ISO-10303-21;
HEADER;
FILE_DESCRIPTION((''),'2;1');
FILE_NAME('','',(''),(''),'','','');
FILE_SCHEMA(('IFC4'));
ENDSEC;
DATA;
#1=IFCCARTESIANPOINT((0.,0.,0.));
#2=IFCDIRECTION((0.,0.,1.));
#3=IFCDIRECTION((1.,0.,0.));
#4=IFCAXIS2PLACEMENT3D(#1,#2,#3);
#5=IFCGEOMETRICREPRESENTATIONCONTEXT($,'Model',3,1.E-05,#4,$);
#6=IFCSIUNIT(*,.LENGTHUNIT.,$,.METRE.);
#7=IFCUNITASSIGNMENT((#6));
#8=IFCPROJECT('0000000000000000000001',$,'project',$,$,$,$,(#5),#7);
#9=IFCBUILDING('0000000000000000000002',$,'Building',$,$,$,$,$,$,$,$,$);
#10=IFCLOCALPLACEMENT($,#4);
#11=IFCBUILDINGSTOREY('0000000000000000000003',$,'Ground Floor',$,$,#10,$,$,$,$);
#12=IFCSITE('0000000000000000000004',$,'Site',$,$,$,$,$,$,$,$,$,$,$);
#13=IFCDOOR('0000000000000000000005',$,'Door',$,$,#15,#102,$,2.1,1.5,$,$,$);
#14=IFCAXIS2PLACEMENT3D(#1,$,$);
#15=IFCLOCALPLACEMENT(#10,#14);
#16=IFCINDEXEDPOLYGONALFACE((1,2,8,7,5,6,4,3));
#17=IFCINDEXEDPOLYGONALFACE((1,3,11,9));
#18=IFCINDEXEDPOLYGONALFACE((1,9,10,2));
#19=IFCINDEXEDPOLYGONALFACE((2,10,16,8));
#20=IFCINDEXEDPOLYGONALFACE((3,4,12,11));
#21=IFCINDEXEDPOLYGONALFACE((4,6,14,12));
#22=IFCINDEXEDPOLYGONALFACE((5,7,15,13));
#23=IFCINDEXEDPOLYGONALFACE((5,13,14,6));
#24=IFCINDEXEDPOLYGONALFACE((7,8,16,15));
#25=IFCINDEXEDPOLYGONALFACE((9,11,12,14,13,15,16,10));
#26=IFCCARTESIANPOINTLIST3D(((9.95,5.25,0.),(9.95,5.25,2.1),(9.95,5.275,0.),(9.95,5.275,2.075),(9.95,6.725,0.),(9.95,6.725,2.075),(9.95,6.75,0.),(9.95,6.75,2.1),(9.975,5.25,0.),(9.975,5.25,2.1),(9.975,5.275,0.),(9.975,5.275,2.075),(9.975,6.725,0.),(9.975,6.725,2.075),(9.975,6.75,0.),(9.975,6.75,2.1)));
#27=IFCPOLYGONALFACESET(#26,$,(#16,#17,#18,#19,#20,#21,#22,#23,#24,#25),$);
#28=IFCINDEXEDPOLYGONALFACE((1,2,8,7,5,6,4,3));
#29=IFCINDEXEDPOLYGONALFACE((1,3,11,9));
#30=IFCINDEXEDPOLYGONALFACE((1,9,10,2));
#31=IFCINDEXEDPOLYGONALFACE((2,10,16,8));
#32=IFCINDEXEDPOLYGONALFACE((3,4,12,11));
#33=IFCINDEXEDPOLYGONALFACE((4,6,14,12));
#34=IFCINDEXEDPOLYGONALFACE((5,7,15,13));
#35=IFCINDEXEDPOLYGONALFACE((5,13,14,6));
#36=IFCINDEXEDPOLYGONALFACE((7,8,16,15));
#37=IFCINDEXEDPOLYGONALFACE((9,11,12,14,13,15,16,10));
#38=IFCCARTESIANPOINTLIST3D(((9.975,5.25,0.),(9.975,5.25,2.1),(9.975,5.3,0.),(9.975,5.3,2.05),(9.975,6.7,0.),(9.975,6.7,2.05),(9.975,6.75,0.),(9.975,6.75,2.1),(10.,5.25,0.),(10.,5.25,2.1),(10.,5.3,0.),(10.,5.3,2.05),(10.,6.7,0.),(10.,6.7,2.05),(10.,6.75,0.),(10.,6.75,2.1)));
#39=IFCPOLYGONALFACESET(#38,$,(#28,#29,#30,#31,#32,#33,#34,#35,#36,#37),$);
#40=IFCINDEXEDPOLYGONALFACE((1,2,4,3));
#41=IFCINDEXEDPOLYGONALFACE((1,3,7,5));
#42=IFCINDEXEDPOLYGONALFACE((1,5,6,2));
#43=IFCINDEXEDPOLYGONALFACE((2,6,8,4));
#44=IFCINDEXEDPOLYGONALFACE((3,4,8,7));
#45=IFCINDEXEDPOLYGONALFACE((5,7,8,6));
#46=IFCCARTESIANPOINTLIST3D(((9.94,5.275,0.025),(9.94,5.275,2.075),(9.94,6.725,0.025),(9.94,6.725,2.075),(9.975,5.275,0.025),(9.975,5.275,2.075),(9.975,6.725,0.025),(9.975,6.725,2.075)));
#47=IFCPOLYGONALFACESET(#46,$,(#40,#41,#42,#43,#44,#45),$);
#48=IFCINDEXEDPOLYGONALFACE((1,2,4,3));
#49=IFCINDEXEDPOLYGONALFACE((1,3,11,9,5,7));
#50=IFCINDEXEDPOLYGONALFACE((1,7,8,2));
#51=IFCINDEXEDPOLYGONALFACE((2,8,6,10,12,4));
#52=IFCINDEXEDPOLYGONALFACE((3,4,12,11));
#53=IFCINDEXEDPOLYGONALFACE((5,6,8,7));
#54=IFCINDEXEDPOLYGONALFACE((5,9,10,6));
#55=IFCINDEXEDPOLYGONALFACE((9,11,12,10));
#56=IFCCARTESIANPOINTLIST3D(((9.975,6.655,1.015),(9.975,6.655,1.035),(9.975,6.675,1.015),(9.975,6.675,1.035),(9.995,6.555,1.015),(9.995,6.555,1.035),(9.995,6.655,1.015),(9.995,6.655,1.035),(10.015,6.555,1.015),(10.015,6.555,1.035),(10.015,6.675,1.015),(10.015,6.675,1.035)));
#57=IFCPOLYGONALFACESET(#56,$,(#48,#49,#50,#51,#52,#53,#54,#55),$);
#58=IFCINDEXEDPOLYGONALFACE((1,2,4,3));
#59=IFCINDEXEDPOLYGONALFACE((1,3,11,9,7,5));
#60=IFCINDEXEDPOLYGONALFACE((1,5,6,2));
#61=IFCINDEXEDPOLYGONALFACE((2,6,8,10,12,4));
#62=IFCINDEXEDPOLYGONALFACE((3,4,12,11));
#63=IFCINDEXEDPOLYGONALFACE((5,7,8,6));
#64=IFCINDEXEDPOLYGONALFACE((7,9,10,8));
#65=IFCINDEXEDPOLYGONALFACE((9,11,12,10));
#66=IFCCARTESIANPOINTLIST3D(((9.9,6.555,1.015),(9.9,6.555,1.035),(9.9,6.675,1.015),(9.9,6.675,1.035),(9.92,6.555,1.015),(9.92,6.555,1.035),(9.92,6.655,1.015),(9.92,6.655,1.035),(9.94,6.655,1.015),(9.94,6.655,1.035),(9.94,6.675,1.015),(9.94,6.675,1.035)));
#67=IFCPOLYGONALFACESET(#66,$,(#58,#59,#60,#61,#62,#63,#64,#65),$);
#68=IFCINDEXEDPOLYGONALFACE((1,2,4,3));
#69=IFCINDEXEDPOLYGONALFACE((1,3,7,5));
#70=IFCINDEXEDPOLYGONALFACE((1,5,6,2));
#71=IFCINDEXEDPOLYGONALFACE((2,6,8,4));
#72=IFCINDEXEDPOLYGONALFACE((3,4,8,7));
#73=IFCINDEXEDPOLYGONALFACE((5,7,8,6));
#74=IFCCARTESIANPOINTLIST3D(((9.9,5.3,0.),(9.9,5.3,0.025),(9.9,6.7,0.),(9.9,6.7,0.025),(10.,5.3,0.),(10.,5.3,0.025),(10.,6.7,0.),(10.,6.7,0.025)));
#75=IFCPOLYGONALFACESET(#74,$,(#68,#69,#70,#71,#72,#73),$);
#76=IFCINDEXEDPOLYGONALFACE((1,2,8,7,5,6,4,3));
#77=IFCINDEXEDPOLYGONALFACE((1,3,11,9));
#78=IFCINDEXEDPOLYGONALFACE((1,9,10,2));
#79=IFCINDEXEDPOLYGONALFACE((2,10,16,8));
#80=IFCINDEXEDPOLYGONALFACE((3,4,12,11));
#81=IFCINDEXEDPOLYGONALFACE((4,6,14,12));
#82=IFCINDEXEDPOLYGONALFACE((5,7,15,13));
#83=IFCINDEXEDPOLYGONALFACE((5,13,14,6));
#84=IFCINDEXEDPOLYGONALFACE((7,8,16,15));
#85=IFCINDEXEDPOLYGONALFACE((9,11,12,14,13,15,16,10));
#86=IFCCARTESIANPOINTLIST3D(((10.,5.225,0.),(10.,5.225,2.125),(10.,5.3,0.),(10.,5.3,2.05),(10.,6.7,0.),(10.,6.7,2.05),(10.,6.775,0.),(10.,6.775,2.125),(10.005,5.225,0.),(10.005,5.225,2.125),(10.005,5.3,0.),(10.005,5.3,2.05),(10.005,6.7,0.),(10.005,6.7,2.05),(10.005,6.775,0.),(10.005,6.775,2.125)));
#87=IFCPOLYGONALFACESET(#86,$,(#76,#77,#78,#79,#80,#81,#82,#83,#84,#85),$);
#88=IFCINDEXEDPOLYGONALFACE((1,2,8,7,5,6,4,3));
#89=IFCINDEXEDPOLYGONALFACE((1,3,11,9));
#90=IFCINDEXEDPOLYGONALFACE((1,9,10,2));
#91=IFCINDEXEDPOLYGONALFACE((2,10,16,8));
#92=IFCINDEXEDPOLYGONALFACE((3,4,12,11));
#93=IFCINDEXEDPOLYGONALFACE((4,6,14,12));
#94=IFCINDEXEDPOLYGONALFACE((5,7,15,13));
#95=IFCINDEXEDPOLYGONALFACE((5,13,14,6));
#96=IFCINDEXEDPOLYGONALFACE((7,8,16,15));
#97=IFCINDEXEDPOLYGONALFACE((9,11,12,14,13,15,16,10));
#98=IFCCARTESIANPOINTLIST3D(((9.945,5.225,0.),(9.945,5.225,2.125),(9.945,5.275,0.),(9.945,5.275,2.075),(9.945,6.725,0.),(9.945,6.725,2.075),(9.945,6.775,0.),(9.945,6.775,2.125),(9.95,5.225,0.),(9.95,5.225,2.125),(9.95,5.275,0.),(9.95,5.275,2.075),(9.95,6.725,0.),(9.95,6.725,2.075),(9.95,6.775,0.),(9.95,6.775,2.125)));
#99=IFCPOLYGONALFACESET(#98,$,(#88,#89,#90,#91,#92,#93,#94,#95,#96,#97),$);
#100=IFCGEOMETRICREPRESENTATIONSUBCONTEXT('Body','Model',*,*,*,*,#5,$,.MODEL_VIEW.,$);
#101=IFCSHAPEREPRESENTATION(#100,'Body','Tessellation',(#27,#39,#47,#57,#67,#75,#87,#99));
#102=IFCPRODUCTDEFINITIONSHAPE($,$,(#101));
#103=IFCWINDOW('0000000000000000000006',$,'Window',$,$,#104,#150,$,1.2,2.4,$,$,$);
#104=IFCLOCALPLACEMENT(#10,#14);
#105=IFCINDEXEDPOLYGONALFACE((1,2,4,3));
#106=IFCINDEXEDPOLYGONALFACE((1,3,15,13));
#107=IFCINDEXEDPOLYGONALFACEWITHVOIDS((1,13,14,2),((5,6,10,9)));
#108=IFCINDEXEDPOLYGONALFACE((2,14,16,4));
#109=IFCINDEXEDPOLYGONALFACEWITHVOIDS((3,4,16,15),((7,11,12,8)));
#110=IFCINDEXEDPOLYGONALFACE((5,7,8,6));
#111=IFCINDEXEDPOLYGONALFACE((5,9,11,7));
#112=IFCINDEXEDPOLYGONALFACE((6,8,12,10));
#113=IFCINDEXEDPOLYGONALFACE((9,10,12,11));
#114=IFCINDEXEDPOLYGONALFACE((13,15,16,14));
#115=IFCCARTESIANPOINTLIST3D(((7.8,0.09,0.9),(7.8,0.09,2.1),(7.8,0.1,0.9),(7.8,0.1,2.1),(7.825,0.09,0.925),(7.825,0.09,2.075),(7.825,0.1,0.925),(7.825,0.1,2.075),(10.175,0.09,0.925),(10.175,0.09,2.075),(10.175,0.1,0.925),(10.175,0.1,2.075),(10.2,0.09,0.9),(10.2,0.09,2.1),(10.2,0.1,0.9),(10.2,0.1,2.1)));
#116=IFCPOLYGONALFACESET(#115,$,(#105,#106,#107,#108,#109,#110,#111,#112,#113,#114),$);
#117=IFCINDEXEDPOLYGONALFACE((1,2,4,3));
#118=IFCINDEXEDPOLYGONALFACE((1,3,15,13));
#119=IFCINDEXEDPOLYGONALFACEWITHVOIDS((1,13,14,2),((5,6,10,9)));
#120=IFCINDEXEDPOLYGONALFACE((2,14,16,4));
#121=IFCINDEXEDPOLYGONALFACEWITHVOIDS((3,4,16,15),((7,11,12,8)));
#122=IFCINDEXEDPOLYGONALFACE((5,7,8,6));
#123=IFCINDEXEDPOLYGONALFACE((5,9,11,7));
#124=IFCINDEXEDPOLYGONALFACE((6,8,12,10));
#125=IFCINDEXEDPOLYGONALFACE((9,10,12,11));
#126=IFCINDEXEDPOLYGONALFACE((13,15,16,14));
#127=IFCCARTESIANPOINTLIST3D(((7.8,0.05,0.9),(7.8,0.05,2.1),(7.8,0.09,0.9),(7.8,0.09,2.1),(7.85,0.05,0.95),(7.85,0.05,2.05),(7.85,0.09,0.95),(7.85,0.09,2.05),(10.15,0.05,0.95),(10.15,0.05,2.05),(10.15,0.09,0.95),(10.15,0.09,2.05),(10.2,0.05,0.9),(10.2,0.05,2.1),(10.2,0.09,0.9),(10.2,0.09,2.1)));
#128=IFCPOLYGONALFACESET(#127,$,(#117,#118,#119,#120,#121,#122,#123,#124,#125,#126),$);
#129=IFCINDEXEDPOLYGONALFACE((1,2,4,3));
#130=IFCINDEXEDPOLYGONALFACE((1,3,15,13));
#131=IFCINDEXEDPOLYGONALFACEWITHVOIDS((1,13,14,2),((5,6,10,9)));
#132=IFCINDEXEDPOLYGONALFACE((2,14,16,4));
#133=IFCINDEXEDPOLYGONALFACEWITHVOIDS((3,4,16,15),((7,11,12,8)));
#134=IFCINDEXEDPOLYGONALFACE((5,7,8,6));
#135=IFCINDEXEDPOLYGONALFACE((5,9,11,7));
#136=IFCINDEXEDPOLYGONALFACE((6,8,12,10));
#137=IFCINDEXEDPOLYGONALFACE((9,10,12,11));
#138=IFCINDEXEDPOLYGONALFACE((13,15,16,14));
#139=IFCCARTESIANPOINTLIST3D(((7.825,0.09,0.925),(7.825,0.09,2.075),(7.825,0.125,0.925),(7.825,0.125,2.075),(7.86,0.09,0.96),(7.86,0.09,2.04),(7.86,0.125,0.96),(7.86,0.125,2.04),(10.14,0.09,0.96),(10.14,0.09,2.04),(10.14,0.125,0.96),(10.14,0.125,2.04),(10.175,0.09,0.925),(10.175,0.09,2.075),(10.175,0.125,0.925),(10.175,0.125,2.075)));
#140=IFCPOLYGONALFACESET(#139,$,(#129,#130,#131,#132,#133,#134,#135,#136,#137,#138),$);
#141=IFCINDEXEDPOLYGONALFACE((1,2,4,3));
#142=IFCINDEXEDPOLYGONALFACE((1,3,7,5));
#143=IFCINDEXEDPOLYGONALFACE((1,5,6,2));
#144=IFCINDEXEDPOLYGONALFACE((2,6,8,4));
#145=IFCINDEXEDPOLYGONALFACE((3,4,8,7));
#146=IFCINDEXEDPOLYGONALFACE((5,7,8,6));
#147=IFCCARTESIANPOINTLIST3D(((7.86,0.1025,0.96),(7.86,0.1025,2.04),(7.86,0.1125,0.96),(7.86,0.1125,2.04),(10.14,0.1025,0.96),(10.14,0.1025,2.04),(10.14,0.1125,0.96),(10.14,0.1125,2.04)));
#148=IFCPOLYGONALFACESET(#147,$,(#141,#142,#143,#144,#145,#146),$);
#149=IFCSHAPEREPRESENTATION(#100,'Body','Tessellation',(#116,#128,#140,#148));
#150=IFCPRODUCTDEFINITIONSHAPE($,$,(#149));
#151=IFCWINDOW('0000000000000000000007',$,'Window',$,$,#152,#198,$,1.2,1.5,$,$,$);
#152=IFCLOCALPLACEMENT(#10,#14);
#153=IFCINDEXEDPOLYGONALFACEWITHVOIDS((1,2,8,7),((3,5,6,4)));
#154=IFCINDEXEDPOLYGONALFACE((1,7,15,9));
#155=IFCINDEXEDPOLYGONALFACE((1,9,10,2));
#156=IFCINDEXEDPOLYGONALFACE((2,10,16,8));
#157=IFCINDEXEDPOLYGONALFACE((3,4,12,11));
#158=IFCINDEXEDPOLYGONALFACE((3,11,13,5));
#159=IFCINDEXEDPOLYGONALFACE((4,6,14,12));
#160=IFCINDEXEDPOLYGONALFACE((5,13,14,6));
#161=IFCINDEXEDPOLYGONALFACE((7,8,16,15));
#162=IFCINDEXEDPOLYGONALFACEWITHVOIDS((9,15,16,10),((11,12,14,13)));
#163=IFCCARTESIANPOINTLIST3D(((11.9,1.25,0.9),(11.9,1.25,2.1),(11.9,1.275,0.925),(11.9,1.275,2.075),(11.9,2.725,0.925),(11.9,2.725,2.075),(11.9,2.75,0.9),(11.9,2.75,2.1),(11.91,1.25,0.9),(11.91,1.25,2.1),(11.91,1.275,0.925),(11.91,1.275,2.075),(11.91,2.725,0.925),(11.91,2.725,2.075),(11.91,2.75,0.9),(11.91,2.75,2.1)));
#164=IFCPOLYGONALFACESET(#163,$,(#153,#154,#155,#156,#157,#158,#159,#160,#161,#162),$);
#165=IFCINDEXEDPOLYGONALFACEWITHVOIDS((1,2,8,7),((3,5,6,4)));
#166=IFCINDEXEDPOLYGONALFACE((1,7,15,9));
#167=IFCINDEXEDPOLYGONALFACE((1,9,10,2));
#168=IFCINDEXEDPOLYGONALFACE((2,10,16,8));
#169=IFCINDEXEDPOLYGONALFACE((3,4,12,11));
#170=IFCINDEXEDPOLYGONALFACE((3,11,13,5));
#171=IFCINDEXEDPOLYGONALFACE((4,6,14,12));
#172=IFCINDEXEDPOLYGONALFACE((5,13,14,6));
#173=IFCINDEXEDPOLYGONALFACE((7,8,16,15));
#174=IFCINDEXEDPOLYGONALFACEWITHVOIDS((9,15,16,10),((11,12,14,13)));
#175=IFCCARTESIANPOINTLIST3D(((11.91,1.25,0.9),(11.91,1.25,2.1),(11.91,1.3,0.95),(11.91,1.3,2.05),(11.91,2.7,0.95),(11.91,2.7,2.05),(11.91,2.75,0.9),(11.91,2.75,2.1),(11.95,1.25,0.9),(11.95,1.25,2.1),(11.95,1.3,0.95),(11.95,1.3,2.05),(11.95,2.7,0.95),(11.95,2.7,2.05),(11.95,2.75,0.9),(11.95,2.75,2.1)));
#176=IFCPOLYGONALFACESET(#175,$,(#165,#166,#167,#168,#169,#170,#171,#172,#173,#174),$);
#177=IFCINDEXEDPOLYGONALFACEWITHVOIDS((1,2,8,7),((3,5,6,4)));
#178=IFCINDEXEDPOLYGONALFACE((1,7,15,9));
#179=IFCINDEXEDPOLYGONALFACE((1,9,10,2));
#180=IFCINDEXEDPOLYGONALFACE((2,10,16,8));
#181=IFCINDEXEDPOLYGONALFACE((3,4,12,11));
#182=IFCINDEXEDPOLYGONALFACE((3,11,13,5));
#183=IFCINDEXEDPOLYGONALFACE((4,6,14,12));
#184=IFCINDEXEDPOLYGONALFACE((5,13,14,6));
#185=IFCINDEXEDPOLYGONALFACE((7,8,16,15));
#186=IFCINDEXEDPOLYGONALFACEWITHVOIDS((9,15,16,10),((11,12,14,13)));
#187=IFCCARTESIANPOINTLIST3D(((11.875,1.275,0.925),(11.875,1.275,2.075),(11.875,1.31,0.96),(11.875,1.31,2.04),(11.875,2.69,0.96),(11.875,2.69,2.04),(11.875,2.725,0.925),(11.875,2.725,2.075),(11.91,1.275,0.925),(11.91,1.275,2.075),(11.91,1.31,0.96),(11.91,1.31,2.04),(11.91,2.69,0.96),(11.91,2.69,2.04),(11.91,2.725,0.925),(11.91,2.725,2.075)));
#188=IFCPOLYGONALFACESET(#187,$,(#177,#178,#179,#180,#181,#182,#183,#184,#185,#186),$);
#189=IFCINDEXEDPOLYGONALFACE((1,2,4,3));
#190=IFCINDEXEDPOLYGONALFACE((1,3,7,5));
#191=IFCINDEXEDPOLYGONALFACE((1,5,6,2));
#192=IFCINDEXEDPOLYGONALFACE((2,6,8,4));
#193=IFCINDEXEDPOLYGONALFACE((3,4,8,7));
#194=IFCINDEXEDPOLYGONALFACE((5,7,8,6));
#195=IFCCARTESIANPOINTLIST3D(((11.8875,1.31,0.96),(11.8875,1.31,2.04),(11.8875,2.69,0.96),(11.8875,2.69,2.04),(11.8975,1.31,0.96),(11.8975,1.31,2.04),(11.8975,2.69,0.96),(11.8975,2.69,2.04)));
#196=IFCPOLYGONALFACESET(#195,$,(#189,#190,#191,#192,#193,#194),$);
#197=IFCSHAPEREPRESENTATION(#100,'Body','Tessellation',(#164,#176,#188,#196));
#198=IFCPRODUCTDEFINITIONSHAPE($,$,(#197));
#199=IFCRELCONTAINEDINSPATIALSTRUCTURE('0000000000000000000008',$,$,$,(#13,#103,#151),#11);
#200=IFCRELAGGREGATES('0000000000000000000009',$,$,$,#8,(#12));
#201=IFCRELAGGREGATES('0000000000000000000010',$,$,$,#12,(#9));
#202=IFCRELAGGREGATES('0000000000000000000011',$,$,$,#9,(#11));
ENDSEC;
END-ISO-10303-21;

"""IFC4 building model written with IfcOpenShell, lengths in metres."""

from ifc_helpers import new_model, si_unit, frame, origin_with_axes, place, context, subcontext, project, spatial, line, indexed_curve, outline, extrude, element, save


model = new_model("IFC4")

# Units and contexts
model_context = context("Model", 3, precision=1e-05, world=origin_with_axes())
body_context = subcontext(model_context, "Body", "Model", "MODEL_VIEW")
ifc_project = project(units=[si_unit("LENGTHUNIT", "METRE")], contexts=[model_context])

# Site, building, storey
site = spatial("IfcSite", under=ifc_project, Name="Site")
building = spatial("IfcBuilding", under=site, Name="Building")
storey_placement = place(None, origin_with_axes())
storey = spatial("IfcBuildingStorey", under=building, at=storey_placement, Name="Ground Floor")

# Door
door_1_placement = place(storey_placement, frame((10.0, 5.25, 0.0), z_axis=(0.0, 0.0, 1.0), x_axis=(0.0, 1.0, 0.0)))
element("IfcDoor", 1, at=door_1_placement, inside=storey, Name="Door", OverallHeight=2.1, OverallWidth=1.5, context=body_context, shape_type="SweptSolid", body=[
    extrude(outline(indexed_curve([(0.0, 0.0), (0.0, 2.1), (1.5, 2.1), (1.5, 0.0), (1.475, 0.0), (1.475, 2.075), (0.025, 2.075), (0.025, 0.0)], segments=[line(1, 2, 3, 4, 5, 6, 7, 8, 1)])), frame((0.0, 0.025, 0.0), z_axis=(0.0, -1.0, 0.0), x_axis=(1.0, 0.0, 0.0)), (0.0, 0.0, -1.0), 0.025),
    extrude(outline(indexed_curve([(0.0, 0.0), (0.0, 2.1), (1.5, 2.1), (1.5, 0.0), (1.45, 0.0), (1.45, 2.05), (0.05, 2.05), (0.05, 0.0)], segments=[line(1, 2, 3, 4, 5, 6, 7, 8, 1)])), frame((0.0, 0.0, 0.0), z_axis=(0.0, -1.0, 0.0), x_axis=(1.0, 0.0, 0.0)), (0.0, 0.0, -1.0), 0.025),
    extrude(outline(indexed_curve([(0.0, 0.0), (1.45, 0.0), (1.45, 0.035), (0.0, 0.035)], segments=[line(1, 2, 3, 4, 1)])), frame((0.025, 0.025, 0.025), z_axis=(0.0, 0.0, 1.0), x_axis=(1.0, 0.0, 0.0)), (0.0, 0.0, 1.0), 2.05),
    extrude(outline(indexed_curve([(0.0, 0.0), (0.0, -0.04), (-0.12, -0.04), (-0.12, -0.02), (-0.02, -0.02), (-0.02, 0.0)], segments=[line(1, 2, 3, 4, 5, 6, 1)])), frame((1.425, 0.025, 1.015), z_axis=(0.0, 0.0, 1.0), x_axis=(1.0, 0.0, 0.0)), (0.0, 0.0, 1.0), 0.02),
    extrude(outline(indexed_curve([(0.0, 0.0), (0.0, 0.04), (-0.12, 0.04), (-0.12, 0.02), (-0.02, 0.02), (-0.02, 0.0)], segments=[line(1, 2, 3, 4, 5, 6, 1)])), frame((1.425, 0.06, 1.015), z_axis=(0.0, 0.0, 1.0), x_axis=(1.0, 0.0, 0.0)), (0.0, 0.0, 1.0), 0.02),
    extrude(outline(indexed_curve([(0.0, 0.0), (1.4, 0.0), (1.4, 0.1), (0.0, 0.1)], segments=[line(1, 2, 3, 4, 1)])), frame((0.05, 0.0, 0.0), z_axis=(0.0, 0.0, 1.0), x_axis=(1.0, 0.0, 0.0)), (0.0, 0.0, 1.0), 0.025),
    extrude(outline(indexed_curve([(0.0, 0.0), (0.0, 2.125), (1.55, 2.125), (1.55, 0.0), (1.475, 0.0), (1.475, 2.05), (0.075, 2.05), (0.075, 0.0)], segments=[line(1, 2, 3, 4, 5, 6, 7, 8, 1)])), frame((-0.025, -0.005, 0.0), z_axis=(0.0, -1.0, 0.0), x_axis=(1.0, 0.0, 0.0)), (0.0, 0.0, -1.0), 0.005),
    extrude(outline(indexed_curve([(0.0, 0.0), (0.0, 2.125), (1.55, 2.125), (1.55, 0.0), (1.5, 0.0), (1.5, 2.075), (0.05, 2.075), (0.05, 0.0)], segments=[line(1, 2, 3, 4, 5, 6, 7, 8, 1)])), frame((-0.025, 0.05, 0.0), z_axis=(0.0, -1.0, 0.0), x_axis=(1.0, 0.0, 0.0)), (0.0, 0.0, -1.0), 0.005),
])

# Windows
window_placement = place(storey_placement, frame((7.8, 0.0, 0.9), z_axis=(0.0, 0.0, 1.0), x_axis=(1.0, 0.0, 0.0)))
element("IfcWindow", 2, at=window_placement, inside=storey, Name="Window", OverallHeight=1.2, OverallWidth=2.4, context=body_context, shape_type="SweptSolid", body=[
    extrude(outline(indexed_curve([(0.0, 0.0), (2.4, 0.0), (2.4, 1.2), (0.0, 1.2)], segments=[line(1, 2, 3, 4, 1)]), holes=[indexed_curve([(0.025, 0.025), (2.375, 0.025), (2.375, 1.175), (0.025, 1.175)], segments=[line(1, 2, 3, 4, 1)])]), frame((0.0, 0.09, 0.0), z_axis=(0.0, -1.0, 0.0), x_axis=(1.0, 0.0, 0.0)), (0.0, 0.0, -1.0), 0.01),
    extrude(outline(indexed_curve([(0.0, 0.0), (2.4, 0.0), (2.4, 1.2), (0.0, 1.2)], segments=[line(1, 2, 3, 4, 1)]), holes=[indexed_curve([(0.05, 0.05), (2.35, 0.05), (2.35, 1.15), (0.05, 1.15)], segments=[line(1, 2, 3, 4, 1)])]), frame((0.0, 0.05, 0.0), z_axis=(0.0, -1.0, 0.0), x_axis=(1.0, 0.0, 0.0)), (0.0, 0.0, -1.0), 0.04),
    extrude(outline(indexed_curve([(0.0, 0.0), (2.35, 0.0), (2.35, 1.15), (0.0, 1.15)], segments=[line(1, 2, 3, 4, 1)]), holes=[indexed_curve([(0.035, 0.035), (2.315, 0.035), (2.315, 1.115), (0.035, 1.115)], segments=[line(1, 2, 3, 4, 1)])]), frame((0.025, 0.09, 0.025), z_axis=(0.0, -1.0, 0.0), x_axis=(1.0, 0.0, 0.0)), (0.0, 0.0, -1.0), 0.035),
    extrude(outline(indexed_curve([(0.035, 0.035), (2.315, 0.035), (2.315, 1.115), (0.035, 1.115)], segments=[line(1, 2, 3, 4, 1)])), frame((0.025, 0.1025, 0.025), z_axis=(0.0, -1.0, 0.0), x_axis=(1.0, 0.0, 0.0)), (0.0, 0.0, -1.0), 0.01),
])
for number, where, z_axis, x_axis, name in (
    (3, (12.0, 1.25, 0.9), (0.0, 0.0, 1.0), (0.0, 1.0, 0.0), "Window"),
):
    element("IfcWindow", number, at=place(storey_placement, frame(where, z_axis=z_axis, x_axis=x_axis)), inside=storey, Name=name, OverallHeight=1.2, OverallWidth=1.5, context=body_context, shape_type="SweptSolid", body=[
        extrude(outline(indexed_curve([(0.0, 0.0), (1.5, 0.0), (1.5, 1.2), (0.0, 1.2)], segments=[line(1, 2, 3, 4, 1)]), holes=[indexed_curve([(0.025, 0.025), (1.475, 0.025), (1.475, 1.175), (0.025, 1.175)], segments=[line(1, 2, 3, 4, 1)])]), frame((0.0, 0.09, 0.0), z_axis=(0.0, -1.0, 0.0), x_axis=(1.0, 0.0, 0.0)), (0.0, 0.0, -1.0), 0.01),
        extrude(outline(indexed_curve([(0.0, 0.0), (1.5, 0.0), (1.5, 1.2), (0.0, 1.2)], segments=[line(1, 2, 3, 4, 1)]), holes=[indexed_curve([(0.05, 0.05), (1.45, 0.05), (1.45, 1.15), (0.05, 1.15)], segments=[line(1, 2, 3, 4, 1)])]), frame((0.0, 0.05, 0.0), z_axis=(0.0, -1.0, 0.0), x_axis=(1.0, 0.0, 0.0)), (0.0, 0.0, -1.0), 0.04),
        extrude(outline(indexed_curve([(0.0, 0.0), (1.45, 0.0), (1.45, 1.15), (0.0, 1.15)], segments=[line(1, 2, 3, 4, 1)]), holes=[indexed_curve([(0.035, 0.035), (1.415, 0.035), (1.415, 1.115), (0.035, 1.115)], segments=[line(1, 2, 3, 4, 1)])]), frame((0.025, 0.09, 0.025), z_axis=(0.0, -1.0, 0.0), x_axis=(1.0, 0.0, 0.0)), (0.0, 0.0, -1.0), 0.035),
        extrude(outline(indexed_curve([(0.035, 0.035), (1.415, 0.035), (1.415, 1.115), (0.035, 1.115)], segments=[line(1, 2, 3, 4, 1)])), frame((0.025, 0.1025, 0.025), z_axis=(0.0, -1.0, 0.0), x_axis=(1.0, 0.0, 0.0)), (0.0, 0.0, -1.0), 0.01),
    ])

save(model, "model.ifc")
